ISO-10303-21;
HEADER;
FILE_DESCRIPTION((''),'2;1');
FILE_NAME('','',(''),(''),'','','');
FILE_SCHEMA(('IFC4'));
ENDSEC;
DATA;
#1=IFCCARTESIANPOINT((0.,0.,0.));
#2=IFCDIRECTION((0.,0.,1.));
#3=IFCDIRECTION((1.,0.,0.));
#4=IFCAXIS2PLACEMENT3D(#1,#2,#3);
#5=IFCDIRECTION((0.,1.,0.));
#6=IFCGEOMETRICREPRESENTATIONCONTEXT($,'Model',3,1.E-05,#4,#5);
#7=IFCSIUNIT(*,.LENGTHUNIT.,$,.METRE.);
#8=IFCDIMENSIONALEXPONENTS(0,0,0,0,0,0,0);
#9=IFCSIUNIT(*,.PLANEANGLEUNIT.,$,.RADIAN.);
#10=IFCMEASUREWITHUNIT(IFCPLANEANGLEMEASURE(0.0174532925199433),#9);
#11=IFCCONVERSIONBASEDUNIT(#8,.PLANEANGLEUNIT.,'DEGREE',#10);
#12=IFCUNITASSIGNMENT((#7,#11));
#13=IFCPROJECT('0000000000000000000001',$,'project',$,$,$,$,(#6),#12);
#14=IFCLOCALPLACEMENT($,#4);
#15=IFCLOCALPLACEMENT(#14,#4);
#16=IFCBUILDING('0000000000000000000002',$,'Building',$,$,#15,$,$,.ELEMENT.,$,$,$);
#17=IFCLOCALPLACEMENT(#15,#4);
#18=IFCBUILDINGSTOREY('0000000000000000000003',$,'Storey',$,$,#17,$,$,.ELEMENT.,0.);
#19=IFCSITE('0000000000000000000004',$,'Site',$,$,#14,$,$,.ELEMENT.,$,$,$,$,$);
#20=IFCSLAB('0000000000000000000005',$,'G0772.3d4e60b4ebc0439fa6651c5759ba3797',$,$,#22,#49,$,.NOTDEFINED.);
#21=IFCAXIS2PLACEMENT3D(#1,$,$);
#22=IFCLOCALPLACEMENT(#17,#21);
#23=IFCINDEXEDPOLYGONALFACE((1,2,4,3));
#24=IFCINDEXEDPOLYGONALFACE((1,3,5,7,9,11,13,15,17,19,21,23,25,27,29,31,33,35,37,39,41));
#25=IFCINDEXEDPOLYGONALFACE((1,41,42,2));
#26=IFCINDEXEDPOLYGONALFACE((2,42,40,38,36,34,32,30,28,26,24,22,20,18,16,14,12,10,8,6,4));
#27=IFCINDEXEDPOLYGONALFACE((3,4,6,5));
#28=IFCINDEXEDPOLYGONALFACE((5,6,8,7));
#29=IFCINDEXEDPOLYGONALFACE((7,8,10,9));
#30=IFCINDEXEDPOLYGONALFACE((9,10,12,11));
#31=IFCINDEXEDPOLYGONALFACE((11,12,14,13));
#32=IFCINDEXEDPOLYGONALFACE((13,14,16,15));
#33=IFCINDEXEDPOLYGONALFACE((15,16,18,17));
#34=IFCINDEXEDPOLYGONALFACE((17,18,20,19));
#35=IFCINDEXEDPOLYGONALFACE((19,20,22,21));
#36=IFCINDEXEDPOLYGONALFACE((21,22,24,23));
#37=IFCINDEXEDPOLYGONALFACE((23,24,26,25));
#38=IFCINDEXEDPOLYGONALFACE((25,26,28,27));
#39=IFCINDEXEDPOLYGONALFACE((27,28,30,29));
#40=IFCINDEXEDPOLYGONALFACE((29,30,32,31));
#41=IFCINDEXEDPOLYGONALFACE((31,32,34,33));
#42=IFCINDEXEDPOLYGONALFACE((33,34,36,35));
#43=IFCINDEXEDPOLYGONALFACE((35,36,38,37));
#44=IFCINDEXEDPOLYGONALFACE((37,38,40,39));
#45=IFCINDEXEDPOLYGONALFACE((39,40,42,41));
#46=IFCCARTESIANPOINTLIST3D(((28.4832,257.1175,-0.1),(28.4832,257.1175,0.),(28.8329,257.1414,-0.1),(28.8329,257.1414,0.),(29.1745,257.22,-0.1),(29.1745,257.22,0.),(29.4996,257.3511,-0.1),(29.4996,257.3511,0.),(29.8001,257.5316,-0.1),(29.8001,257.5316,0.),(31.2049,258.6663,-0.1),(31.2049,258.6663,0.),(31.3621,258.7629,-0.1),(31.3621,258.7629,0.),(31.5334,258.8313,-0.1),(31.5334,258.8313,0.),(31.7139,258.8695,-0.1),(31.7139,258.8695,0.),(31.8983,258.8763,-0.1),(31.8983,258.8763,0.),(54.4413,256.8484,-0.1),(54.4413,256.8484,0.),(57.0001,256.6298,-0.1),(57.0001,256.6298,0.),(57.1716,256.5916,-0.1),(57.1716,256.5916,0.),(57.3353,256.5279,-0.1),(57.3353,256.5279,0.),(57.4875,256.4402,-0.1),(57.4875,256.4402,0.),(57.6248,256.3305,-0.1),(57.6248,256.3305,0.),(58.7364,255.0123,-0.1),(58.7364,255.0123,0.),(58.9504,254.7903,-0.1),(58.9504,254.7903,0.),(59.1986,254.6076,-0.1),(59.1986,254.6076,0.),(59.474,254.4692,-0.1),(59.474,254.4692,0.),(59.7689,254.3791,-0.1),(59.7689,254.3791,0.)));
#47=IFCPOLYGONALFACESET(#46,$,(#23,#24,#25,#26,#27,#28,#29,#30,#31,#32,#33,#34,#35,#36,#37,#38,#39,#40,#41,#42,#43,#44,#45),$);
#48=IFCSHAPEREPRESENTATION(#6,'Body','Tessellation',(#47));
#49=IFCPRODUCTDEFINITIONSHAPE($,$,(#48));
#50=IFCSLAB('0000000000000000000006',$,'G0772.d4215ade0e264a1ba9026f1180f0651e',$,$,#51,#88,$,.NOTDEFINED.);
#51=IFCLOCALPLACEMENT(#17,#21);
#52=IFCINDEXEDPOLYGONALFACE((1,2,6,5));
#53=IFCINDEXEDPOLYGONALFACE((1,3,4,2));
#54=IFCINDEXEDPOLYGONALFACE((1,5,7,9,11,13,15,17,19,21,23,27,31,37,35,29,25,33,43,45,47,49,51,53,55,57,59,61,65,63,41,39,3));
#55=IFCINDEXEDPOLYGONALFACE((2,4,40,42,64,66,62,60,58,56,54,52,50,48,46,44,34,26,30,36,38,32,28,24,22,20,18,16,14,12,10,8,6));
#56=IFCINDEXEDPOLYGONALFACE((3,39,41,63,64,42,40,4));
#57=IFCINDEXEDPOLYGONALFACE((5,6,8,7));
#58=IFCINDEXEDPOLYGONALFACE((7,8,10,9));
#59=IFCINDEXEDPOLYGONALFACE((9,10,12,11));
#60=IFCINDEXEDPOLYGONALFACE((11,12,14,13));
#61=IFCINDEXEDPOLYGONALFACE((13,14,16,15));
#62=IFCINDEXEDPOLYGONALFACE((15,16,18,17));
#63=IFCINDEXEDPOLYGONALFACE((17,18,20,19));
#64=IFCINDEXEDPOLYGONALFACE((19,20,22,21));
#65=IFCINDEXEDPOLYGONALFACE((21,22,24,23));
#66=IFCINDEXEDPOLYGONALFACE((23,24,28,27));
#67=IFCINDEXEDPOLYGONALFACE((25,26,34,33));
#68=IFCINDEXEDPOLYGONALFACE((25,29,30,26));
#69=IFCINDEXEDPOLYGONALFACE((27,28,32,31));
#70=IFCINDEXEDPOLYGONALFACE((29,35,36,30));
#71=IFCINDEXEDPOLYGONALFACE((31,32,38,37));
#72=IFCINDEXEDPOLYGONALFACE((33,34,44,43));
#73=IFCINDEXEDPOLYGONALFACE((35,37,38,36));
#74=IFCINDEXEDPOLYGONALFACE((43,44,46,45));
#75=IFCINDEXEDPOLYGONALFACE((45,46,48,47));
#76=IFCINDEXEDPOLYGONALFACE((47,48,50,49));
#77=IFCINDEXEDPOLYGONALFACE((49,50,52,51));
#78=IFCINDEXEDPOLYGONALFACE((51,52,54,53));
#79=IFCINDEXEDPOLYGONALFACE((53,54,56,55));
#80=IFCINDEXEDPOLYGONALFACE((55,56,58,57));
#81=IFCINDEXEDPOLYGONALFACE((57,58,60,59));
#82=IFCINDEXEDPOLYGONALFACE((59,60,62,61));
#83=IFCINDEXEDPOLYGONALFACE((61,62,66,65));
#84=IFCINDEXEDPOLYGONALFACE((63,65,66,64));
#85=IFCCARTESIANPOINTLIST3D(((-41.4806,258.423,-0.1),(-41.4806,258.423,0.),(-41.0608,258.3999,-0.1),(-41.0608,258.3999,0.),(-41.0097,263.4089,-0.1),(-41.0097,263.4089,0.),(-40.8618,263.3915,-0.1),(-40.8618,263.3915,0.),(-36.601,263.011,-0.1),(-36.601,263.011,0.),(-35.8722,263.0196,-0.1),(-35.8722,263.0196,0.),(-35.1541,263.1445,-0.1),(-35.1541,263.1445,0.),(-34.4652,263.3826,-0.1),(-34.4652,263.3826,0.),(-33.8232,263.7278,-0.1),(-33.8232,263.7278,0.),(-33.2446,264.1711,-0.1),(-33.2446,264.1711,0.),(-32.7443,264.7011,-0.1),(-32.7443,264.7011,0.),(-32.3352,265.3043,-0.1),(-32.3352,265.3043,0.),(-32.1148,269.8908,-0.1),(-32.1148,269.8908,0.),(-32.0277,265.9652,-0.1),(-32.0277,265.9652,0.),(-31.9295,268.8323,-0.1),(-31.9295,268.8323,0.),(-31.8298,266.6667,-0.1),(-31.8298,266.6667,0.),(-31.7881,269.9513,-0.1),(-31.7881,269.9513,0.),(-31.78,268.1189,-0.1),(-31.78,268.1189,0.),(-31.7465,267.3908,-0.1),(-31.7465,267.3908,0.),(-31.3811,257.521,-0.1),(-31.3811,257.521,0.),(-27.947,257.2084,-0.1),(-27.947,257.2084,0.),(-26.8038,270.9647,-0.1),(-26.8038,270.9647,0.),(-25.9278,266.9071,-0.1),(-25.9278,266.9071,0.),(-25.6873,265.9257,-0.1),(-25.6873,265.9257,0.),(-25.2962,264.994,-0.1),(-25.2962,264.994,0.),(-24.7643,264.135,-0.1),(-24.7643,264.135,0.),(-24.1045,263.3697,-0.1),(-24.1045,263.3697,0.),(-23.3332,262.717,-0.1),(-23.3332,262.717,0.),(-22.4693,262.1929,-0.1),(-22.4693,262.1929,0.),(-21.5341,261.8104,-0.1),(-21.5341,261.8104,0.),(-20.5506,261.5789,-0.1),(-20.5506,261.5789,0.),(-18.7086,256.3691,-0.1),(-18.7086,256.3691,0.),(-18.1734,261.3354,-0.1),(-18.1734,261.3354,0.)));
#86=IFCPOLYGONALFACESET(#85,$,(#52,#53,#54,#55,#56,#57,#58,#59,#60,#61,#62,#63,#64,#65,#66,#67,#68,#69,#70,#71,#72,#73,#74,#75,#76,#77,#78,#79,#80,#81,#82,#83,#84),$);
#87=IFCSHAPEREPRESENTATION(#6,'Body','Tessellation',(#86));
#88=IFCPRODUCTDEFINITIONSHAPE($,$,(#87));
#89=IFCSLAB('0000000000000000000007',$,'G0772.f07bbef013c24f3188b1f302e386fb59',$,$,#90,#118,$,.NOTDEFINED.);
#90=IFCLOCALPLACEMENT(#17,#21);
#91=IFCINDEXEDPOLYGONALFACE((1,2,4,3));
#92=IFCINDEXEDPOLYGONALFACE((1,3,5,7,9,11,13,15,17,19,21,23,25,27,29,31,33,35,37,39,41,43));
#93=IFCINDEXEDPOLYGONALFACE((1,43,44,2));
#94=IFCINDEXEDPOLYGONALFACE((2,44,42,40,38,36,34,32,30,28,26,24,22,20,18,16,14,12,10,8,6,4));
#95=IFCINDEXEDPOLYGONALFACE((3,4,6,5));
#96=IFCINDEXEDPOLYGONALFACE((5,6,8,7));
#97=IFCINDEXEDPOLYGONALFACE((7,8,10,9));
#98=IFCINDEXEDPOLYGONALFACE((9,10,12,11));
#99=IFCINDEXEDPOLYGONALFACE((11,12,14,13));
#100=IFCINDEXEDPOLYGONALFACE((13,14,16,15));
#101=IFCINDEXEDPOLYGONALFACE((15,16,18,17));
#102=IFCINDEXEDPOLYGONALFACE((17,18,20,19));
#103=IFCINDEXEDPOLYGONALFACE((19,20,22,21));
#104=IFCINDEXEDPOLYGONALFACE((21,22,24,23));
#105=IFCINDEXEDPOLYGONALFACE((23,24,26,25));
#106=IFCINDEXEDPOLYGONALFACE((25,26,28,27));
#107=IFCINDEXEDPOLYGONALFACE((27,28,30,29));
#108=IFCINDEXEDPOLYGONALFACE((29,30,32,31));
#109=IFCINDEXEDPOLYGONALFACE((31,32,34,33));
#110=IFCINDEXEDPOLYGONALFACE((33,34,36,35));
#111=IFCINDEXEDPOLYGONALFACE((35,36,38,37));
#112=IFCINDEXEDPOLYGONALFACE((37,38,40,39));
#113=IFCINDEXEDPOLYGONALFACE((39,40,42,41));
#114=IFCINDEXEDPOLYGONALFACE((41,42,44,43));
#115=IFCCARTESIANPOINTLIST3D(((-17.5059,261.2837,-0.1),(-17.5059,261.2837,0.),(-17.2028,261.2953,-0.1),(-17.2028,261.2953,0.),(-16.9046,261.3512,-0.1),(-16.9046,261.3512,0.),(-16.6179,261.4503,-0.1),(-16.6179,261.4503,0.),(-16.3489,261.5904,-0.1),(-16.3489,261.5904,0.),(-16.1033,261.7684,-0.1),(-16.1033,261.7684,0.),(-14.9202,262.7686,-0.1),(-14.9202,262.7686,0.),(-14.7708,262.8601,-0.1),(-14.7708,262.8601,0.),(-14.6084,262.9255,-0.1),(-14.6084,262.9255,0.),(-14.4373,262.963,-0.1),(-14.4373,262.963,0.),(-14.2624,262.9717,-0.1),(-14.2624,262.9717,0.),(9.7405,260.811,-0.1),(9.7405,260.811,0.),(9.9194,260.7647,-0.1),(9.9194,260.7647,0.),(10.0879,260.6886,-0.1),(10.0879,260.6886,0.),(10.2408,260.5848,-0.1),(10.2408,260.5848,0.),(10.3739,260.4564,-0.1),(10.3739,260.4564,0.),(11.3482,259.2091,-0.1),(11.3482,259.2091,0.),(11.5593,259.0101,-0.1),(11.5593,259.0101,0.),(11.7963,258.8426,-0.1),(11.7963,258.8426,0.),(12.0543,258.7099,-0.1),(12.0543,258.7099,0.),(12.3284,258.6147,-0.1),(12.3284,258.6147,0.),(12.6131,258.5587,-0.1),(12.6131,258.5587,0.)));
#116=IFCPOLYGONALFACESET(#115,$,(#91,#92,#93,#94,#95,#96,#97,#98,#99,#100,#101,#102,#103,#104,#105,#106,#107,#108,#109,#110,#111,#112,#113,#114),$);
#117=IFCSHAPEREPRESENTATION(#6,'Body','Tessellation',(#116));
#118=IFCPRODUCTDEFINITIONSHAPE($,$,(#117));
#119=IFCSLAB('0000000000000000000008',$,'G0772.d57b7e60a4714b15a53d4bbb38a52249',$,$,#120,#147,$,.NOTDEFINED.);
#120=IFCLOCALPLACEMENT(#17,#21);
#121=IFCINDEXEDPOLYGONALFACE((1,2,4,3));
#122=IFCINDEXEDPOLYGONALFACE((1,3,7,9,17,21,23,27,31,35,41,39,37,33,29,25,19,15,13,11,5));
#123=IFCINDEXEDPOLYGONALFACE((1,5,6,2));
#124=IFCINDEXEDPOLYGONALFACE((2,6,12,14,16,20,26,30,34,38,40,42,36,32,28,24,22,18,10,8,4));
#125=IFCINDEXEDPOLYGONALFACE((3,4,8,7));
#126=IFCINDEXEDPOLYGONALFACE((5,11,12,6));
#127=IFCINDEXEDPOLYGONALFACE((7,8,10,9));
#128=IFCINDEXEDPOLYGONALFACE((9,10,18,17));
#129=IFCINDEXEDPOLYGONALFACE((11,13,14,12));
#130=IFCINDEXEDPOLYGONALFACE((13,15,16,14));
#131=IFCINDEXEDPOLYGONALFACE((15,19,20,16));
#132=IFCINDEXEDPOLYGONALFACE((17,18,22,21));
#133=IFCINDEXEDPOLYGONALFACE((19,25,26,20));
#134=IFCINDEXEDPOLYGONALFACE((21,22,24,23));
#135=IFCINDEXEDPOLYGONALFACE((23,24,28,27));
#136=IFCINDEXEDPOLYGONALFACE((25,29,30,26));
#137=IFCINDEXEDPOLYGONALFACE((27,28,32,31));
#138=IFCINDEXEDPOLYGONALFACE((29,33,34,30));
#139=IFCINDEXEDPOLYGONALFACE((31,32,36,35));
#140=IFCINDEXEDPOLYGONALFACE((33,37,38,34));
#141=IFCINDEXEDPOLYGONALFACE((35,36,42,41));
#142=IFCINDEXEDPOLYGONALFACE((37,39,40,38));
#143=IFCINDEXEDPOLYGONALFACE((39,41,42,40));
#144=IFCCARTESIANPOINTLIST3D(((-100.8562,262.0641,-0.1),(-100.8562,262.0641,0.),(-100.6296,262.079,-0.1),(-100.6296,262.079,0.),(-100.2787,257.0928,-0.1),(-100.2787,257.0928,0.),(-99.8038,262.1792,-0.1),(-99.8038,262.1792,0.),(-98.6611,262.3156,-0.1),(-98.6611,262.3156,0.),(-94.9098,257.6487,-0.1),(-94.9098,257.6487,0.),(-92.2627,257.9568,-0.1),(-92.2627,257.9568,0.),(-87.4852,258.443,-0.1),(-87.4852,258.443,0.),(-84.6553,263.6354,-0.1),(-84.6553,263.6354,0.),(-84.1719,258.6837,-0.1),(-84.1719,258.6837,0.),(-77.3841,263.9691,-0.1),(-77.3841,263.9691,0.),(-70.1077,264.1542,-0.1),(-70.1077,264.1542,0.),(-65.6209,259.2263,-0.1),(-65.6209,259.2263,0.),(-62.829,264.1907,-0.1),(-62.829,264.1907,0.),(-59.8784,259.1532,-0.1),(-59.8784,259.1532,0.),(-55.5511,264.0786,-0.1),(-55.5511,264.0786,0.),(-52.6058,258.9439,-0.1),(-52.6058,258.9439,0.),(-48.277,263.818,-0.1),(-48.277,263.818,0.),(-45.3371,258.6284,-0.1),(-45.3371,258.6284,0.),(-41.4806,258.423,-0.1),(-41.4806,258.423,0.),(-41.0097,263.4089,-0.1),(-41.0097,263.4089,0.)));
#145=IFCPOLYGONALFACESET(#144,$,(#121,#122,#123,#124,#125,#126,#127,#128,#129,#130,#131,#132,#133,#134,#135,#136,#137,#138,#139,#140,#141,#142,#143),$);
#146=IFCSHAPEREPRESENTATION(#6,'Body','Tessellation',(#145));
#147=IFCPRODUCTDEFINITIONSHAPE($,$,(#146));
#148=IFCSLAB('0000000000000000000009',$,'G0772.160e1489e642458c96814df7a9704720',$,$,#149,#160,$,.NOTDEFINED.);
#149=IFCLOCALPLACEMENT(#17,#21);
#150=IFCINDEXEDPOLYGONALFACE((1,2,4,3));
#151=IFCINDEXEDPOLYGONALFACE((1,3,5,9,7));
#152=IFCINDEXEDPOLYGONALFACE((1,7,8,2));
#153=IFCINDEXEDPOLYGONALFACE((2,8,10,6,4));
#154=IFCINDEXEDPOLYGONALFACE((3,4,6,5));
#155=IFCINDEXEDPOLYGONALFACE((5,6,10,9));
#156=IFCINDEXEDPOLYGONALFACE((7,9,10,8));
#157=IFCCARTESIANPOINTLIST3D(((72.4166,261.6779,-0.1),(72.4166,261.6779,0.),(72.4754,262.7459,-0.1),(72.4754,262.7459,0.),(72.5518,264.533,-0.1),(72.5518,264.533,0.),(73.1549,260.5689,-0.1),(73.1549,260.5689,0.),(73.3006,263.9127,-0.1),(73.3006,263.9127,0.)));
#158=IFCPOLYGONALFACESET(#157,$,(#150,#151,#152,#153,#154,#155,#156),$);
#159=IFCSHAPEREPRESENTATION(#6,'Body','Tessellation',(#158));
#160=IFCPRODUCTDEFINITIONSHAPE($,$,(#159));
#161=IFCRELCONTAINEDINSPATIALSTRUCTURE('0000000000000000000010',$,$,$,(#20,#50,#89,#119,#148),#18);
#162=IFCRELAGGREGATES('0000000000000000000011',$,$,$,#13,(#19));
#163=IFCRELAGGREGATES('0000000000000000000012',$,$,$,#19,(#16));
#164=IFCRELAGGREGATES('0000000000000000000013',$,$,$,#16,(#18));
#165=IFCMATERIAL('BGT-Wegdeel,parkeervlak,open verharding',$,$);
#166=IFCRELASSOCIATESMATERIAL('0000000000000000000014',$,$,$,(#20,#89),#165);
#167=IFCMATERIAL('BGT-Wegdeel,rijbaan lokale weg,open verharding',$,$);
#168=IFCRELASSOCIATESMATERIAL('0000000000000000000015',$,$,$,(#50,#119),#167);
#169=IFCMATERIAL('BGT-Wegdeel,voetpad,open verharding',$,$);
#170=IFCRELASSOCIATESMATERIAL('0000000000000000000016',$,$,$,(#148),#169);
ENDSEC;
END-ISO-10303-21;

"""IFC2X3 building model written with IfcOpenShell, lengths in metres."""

from ifc_helpers import new_model, entity, si_unit, converted_unit, direction, frame, origin_with_axes, place, context, project, spatial, polyline, outline, extrude, material, element, save


model = new_model("IFC2X3")

# Units and contexts
model_context = context("Model", 3, precision=1e-05, world=origin_with_axes(), true_north=direction((0.0, 1.0, 0.0)))
ifc_project = project(units=[si_unit("LENGTHUNIT", "METRE"), converted_unit("PLANEANGLEUNIT", "DEGREE", entity("IfcPlaneAngleMeasure", 0.0174532925199433), si_unit("PLANEANGLEUNIT", "RADIAN"), dimensions=[0, 0, 0, 0, 0, 0, 0])], contexts=[model_context])

# Site, building, storey
site_placement = place(None, origin_with_axes())
site = spatial("IfcSite", under=ifc_project, at=site_placement, Name="Site", CompositionType="ELEMENT")
building_placement = place(site_placement, origin_with_axes())
building = spatial("IfcBuilding", under=site, at=building_placement, Name="Building", CompositionType="ELEMENT")
storey_placement = place(building_placement, origin_with_axes())
storey = spatial("IfcBuildingStorey", under=building, at=storey_placement, Name="Storey", CompositionType="ELEMENT", Elevation=0.0)

# Slabs
ifc_material_1 = material(Name="BGT-Wegdeel,voetpad,open verharding")
ifc_material_2 = material(Name="BGT-Wegdeel,parkeervlak,open verharding")
slab_1_placement = place(storey_placement, frame((0.0, 0.0, -0.1), z_axis=(0.0, 0.0, 1.0), x_axis=(1.0, 0.0, 0.0)))
element("IfcSlab", 1, at=slab_1_placement, inside=storey, material=ifc_material_2, Name="G0772.3d4e60b4ebc0439fa6651c5759ba3797", PredefinedType="NOTDEFINED", context=model_context, shape_type="SweptSolid", body=[
    extrude(outline(polyline([(54.4413, 256.8484), (57.0001, 256.6298), (57.1716, 256.5916), (57.3353, 256.5279), (57.4875, 256.4402), (57.6248, 256.3305), (58.7364, 255.0123), (58.9504, 254.7903), (59.1986, 254.6076), (59.474, 254.4692), (59.7689, 254.3791), (28.4832, 257.1175), (28.8329, 257.1414), (29.1745, 257.22), (29.4996, 257.3511), (29.8001, 257.5316), (31.2049, 258.6663), (31.3621, 258.7629), (31.5334, 258.8313), (31.7139, 258.8695), (31.8983, 258.8763), (54.4413, 256.8484)])), origin_with_axes(), (0.0, 0.0, 1.0), 0.1),
])
ifc_material_3 = material(Name="BGT-Wegdeel,rijbaan lokale weg,open verharding")
slab_2_placement = place(storey_placement, frame((0.0, 0.0, -0.1), z_axis=(0.0, 0.0, 1.0), x_axis=(1.0, 0.0, 0.0)))
element("IfcSlab", 2, at=slab_2_placement, inside=storey, material=ifc_material_3, Name="G0772.d4215ade0e264a1ba9026f1180f0651e", PredefinedType="NOTDEFINED", context=model_context, shape_type="SweptSolid", body=[
    extrude(outline(polyline([(-25.9278, 266.9071), (-25.6873, 265.9257), (-25.2962, 264.994), (-24.7643, 264.135), (-24.1045, 263.3697), (-23.3332, 262.717), (-22.4693, 262.1929), (-21.5341, 261.8104), (-20.5506, 261.5789), (-18.1734, 261.3354), (-18.7086, 256.3691), (-27.947, 257.2084), (-31.3811, 257.521), (-41.0608, 258.3999), (-41.4806, 258.423), (-41.0097, 263.4089), (-40.8618, 263.3915), (-36.601, 263.011), (-35.8722, 263.0196), (-35.1541, 263.1445), (-34.4652, 263.3826), (-33.8232, 263.7278), (-33.2446, 264.1711), (-32.7443, 264.7011), (-32.3352, 265.3043), (-32.0277, 265.9652), (-31.8298, 266.6667), (-31.7465, 267.3908), (-31.78, 268.1189), (-31.9295, 268.8323), (-32.1148, 269.8908), (-31.7881, 269.9513), (-26.8038, 270.9647), (-25.9278, 266.9071)])), origin_with_axes(), (0.0, 0.0, 1.0), 0.1),
])
slab_3_placement = place(storey_placement, frame((0.0, 0.0, -0.1), z_axis=(0.0, 0.0, 1.0), x_axis=(1.0, 0.0, 0.0)))
element("IfcSlab", 3, at=slab_3_placement, inside=storey, material=ifc_material_2, Name="G0772.f07bbef013c24f3188b1f302e386fb59", PredefinedType="NOTDEFINED", context=model_context, shape_type="SweptSolid", body=[
    extrude(outline(polyline([(-17.2028, 261.2953), (-16.9046, 261.3512), (-16.6179, 261.4503), (-16.3489, 261.5904), (-16.1033, 261.7684), (-14.9202, 262.7686), (-14.7708, 262.8601), (-14.6084, 262.9255), (-14.4373, 262.963), (-14.2624, 262.9717), (9.7405, 260.811), (9.9194, 260.7647), (10.0879, 260.6886), (10.2408, 260.5848), (10.3739, 260.4564), (11.3482, 259.2091), (11.5593, 259.0101), (11.7963, 258.8426), (12.0543, 258.7099), (12.3284, 258.6147), (12.6131, 258.5587), (-17.5059, 261.2837), (-17.2028, 261.2953)])), origin_with_axes(), (0.0, 0.0, 1.0), 0.1),
])
slab_4_placement = place(storey_placement, frame((0.0, 0.0, -0.1), z_axis=(0.0, 0.0, 1.0), x_axis=(1.0, 0.0, 0.0)))
element("IfcSlab", 4, at=slab_4_placement, inside=storey, material=ifc_material_3, Name="G0772.d57b7e60a4714b15a53d4bbb38a52249", PredefinedType="NOTDEFINED", context=model_context, shape_type="SweptSolid", body=[
    extrude(outline(polyline([(-77.3841, 263.9691), (-70.1077, 264.1542), (-62.829, 264.1907), (-55.5511, 264.0786), (-48.277, 263.818), (-41.0097, 263.4089), (-41.4806, 258.423), (-45.3371, 258.6284), (-52.6058, 258.9439), (-59.8784, 259.1532), (-65.6209, 259.2263), (-84.1719, 258.6837), (-87.4852, 258.443), (-92.2627, 257.9568), (-94.9098, 257.6487), (-100.2787, 257.0928), (-100.8562, 262.0641), (-100.6296, 262.079), (-99.8038, 262.1792), (-98.6611, 262.3156), (-84.6553, 263.6354), (-77.3841, 263.9691)])), origin_with_axes(), (0.0, 0.0, 1.0), 0.1),
])
slab_5_placement = place(storey_placement, frame((0.0, 0.0, -0.1), z_axis=(0.0, 0.0, 1.0), x_axis=(1.0, 0.0, 0.0)))
element("IfcSlab", 5, at=slab_5_placement, inside=storey, material=ifc_material_1, Name="G0772.160e1489e642458c96814df7a9704720", PredefinedType="NOTDEFINED", context=model_context, shape_type="SweptSolid", body=[
    extrude(outline(polyline([(73.1549, 260.5689), (72.4166, 261.6779), (72.4754, 262.7459), (72.5518, 264.533), (73.3006, 263.9127), (73.1549, 260.5689)])), origin_with_axes(), (0.0, 0.0, 1.0), 0.1),
])

save(model, "model.ifc")
